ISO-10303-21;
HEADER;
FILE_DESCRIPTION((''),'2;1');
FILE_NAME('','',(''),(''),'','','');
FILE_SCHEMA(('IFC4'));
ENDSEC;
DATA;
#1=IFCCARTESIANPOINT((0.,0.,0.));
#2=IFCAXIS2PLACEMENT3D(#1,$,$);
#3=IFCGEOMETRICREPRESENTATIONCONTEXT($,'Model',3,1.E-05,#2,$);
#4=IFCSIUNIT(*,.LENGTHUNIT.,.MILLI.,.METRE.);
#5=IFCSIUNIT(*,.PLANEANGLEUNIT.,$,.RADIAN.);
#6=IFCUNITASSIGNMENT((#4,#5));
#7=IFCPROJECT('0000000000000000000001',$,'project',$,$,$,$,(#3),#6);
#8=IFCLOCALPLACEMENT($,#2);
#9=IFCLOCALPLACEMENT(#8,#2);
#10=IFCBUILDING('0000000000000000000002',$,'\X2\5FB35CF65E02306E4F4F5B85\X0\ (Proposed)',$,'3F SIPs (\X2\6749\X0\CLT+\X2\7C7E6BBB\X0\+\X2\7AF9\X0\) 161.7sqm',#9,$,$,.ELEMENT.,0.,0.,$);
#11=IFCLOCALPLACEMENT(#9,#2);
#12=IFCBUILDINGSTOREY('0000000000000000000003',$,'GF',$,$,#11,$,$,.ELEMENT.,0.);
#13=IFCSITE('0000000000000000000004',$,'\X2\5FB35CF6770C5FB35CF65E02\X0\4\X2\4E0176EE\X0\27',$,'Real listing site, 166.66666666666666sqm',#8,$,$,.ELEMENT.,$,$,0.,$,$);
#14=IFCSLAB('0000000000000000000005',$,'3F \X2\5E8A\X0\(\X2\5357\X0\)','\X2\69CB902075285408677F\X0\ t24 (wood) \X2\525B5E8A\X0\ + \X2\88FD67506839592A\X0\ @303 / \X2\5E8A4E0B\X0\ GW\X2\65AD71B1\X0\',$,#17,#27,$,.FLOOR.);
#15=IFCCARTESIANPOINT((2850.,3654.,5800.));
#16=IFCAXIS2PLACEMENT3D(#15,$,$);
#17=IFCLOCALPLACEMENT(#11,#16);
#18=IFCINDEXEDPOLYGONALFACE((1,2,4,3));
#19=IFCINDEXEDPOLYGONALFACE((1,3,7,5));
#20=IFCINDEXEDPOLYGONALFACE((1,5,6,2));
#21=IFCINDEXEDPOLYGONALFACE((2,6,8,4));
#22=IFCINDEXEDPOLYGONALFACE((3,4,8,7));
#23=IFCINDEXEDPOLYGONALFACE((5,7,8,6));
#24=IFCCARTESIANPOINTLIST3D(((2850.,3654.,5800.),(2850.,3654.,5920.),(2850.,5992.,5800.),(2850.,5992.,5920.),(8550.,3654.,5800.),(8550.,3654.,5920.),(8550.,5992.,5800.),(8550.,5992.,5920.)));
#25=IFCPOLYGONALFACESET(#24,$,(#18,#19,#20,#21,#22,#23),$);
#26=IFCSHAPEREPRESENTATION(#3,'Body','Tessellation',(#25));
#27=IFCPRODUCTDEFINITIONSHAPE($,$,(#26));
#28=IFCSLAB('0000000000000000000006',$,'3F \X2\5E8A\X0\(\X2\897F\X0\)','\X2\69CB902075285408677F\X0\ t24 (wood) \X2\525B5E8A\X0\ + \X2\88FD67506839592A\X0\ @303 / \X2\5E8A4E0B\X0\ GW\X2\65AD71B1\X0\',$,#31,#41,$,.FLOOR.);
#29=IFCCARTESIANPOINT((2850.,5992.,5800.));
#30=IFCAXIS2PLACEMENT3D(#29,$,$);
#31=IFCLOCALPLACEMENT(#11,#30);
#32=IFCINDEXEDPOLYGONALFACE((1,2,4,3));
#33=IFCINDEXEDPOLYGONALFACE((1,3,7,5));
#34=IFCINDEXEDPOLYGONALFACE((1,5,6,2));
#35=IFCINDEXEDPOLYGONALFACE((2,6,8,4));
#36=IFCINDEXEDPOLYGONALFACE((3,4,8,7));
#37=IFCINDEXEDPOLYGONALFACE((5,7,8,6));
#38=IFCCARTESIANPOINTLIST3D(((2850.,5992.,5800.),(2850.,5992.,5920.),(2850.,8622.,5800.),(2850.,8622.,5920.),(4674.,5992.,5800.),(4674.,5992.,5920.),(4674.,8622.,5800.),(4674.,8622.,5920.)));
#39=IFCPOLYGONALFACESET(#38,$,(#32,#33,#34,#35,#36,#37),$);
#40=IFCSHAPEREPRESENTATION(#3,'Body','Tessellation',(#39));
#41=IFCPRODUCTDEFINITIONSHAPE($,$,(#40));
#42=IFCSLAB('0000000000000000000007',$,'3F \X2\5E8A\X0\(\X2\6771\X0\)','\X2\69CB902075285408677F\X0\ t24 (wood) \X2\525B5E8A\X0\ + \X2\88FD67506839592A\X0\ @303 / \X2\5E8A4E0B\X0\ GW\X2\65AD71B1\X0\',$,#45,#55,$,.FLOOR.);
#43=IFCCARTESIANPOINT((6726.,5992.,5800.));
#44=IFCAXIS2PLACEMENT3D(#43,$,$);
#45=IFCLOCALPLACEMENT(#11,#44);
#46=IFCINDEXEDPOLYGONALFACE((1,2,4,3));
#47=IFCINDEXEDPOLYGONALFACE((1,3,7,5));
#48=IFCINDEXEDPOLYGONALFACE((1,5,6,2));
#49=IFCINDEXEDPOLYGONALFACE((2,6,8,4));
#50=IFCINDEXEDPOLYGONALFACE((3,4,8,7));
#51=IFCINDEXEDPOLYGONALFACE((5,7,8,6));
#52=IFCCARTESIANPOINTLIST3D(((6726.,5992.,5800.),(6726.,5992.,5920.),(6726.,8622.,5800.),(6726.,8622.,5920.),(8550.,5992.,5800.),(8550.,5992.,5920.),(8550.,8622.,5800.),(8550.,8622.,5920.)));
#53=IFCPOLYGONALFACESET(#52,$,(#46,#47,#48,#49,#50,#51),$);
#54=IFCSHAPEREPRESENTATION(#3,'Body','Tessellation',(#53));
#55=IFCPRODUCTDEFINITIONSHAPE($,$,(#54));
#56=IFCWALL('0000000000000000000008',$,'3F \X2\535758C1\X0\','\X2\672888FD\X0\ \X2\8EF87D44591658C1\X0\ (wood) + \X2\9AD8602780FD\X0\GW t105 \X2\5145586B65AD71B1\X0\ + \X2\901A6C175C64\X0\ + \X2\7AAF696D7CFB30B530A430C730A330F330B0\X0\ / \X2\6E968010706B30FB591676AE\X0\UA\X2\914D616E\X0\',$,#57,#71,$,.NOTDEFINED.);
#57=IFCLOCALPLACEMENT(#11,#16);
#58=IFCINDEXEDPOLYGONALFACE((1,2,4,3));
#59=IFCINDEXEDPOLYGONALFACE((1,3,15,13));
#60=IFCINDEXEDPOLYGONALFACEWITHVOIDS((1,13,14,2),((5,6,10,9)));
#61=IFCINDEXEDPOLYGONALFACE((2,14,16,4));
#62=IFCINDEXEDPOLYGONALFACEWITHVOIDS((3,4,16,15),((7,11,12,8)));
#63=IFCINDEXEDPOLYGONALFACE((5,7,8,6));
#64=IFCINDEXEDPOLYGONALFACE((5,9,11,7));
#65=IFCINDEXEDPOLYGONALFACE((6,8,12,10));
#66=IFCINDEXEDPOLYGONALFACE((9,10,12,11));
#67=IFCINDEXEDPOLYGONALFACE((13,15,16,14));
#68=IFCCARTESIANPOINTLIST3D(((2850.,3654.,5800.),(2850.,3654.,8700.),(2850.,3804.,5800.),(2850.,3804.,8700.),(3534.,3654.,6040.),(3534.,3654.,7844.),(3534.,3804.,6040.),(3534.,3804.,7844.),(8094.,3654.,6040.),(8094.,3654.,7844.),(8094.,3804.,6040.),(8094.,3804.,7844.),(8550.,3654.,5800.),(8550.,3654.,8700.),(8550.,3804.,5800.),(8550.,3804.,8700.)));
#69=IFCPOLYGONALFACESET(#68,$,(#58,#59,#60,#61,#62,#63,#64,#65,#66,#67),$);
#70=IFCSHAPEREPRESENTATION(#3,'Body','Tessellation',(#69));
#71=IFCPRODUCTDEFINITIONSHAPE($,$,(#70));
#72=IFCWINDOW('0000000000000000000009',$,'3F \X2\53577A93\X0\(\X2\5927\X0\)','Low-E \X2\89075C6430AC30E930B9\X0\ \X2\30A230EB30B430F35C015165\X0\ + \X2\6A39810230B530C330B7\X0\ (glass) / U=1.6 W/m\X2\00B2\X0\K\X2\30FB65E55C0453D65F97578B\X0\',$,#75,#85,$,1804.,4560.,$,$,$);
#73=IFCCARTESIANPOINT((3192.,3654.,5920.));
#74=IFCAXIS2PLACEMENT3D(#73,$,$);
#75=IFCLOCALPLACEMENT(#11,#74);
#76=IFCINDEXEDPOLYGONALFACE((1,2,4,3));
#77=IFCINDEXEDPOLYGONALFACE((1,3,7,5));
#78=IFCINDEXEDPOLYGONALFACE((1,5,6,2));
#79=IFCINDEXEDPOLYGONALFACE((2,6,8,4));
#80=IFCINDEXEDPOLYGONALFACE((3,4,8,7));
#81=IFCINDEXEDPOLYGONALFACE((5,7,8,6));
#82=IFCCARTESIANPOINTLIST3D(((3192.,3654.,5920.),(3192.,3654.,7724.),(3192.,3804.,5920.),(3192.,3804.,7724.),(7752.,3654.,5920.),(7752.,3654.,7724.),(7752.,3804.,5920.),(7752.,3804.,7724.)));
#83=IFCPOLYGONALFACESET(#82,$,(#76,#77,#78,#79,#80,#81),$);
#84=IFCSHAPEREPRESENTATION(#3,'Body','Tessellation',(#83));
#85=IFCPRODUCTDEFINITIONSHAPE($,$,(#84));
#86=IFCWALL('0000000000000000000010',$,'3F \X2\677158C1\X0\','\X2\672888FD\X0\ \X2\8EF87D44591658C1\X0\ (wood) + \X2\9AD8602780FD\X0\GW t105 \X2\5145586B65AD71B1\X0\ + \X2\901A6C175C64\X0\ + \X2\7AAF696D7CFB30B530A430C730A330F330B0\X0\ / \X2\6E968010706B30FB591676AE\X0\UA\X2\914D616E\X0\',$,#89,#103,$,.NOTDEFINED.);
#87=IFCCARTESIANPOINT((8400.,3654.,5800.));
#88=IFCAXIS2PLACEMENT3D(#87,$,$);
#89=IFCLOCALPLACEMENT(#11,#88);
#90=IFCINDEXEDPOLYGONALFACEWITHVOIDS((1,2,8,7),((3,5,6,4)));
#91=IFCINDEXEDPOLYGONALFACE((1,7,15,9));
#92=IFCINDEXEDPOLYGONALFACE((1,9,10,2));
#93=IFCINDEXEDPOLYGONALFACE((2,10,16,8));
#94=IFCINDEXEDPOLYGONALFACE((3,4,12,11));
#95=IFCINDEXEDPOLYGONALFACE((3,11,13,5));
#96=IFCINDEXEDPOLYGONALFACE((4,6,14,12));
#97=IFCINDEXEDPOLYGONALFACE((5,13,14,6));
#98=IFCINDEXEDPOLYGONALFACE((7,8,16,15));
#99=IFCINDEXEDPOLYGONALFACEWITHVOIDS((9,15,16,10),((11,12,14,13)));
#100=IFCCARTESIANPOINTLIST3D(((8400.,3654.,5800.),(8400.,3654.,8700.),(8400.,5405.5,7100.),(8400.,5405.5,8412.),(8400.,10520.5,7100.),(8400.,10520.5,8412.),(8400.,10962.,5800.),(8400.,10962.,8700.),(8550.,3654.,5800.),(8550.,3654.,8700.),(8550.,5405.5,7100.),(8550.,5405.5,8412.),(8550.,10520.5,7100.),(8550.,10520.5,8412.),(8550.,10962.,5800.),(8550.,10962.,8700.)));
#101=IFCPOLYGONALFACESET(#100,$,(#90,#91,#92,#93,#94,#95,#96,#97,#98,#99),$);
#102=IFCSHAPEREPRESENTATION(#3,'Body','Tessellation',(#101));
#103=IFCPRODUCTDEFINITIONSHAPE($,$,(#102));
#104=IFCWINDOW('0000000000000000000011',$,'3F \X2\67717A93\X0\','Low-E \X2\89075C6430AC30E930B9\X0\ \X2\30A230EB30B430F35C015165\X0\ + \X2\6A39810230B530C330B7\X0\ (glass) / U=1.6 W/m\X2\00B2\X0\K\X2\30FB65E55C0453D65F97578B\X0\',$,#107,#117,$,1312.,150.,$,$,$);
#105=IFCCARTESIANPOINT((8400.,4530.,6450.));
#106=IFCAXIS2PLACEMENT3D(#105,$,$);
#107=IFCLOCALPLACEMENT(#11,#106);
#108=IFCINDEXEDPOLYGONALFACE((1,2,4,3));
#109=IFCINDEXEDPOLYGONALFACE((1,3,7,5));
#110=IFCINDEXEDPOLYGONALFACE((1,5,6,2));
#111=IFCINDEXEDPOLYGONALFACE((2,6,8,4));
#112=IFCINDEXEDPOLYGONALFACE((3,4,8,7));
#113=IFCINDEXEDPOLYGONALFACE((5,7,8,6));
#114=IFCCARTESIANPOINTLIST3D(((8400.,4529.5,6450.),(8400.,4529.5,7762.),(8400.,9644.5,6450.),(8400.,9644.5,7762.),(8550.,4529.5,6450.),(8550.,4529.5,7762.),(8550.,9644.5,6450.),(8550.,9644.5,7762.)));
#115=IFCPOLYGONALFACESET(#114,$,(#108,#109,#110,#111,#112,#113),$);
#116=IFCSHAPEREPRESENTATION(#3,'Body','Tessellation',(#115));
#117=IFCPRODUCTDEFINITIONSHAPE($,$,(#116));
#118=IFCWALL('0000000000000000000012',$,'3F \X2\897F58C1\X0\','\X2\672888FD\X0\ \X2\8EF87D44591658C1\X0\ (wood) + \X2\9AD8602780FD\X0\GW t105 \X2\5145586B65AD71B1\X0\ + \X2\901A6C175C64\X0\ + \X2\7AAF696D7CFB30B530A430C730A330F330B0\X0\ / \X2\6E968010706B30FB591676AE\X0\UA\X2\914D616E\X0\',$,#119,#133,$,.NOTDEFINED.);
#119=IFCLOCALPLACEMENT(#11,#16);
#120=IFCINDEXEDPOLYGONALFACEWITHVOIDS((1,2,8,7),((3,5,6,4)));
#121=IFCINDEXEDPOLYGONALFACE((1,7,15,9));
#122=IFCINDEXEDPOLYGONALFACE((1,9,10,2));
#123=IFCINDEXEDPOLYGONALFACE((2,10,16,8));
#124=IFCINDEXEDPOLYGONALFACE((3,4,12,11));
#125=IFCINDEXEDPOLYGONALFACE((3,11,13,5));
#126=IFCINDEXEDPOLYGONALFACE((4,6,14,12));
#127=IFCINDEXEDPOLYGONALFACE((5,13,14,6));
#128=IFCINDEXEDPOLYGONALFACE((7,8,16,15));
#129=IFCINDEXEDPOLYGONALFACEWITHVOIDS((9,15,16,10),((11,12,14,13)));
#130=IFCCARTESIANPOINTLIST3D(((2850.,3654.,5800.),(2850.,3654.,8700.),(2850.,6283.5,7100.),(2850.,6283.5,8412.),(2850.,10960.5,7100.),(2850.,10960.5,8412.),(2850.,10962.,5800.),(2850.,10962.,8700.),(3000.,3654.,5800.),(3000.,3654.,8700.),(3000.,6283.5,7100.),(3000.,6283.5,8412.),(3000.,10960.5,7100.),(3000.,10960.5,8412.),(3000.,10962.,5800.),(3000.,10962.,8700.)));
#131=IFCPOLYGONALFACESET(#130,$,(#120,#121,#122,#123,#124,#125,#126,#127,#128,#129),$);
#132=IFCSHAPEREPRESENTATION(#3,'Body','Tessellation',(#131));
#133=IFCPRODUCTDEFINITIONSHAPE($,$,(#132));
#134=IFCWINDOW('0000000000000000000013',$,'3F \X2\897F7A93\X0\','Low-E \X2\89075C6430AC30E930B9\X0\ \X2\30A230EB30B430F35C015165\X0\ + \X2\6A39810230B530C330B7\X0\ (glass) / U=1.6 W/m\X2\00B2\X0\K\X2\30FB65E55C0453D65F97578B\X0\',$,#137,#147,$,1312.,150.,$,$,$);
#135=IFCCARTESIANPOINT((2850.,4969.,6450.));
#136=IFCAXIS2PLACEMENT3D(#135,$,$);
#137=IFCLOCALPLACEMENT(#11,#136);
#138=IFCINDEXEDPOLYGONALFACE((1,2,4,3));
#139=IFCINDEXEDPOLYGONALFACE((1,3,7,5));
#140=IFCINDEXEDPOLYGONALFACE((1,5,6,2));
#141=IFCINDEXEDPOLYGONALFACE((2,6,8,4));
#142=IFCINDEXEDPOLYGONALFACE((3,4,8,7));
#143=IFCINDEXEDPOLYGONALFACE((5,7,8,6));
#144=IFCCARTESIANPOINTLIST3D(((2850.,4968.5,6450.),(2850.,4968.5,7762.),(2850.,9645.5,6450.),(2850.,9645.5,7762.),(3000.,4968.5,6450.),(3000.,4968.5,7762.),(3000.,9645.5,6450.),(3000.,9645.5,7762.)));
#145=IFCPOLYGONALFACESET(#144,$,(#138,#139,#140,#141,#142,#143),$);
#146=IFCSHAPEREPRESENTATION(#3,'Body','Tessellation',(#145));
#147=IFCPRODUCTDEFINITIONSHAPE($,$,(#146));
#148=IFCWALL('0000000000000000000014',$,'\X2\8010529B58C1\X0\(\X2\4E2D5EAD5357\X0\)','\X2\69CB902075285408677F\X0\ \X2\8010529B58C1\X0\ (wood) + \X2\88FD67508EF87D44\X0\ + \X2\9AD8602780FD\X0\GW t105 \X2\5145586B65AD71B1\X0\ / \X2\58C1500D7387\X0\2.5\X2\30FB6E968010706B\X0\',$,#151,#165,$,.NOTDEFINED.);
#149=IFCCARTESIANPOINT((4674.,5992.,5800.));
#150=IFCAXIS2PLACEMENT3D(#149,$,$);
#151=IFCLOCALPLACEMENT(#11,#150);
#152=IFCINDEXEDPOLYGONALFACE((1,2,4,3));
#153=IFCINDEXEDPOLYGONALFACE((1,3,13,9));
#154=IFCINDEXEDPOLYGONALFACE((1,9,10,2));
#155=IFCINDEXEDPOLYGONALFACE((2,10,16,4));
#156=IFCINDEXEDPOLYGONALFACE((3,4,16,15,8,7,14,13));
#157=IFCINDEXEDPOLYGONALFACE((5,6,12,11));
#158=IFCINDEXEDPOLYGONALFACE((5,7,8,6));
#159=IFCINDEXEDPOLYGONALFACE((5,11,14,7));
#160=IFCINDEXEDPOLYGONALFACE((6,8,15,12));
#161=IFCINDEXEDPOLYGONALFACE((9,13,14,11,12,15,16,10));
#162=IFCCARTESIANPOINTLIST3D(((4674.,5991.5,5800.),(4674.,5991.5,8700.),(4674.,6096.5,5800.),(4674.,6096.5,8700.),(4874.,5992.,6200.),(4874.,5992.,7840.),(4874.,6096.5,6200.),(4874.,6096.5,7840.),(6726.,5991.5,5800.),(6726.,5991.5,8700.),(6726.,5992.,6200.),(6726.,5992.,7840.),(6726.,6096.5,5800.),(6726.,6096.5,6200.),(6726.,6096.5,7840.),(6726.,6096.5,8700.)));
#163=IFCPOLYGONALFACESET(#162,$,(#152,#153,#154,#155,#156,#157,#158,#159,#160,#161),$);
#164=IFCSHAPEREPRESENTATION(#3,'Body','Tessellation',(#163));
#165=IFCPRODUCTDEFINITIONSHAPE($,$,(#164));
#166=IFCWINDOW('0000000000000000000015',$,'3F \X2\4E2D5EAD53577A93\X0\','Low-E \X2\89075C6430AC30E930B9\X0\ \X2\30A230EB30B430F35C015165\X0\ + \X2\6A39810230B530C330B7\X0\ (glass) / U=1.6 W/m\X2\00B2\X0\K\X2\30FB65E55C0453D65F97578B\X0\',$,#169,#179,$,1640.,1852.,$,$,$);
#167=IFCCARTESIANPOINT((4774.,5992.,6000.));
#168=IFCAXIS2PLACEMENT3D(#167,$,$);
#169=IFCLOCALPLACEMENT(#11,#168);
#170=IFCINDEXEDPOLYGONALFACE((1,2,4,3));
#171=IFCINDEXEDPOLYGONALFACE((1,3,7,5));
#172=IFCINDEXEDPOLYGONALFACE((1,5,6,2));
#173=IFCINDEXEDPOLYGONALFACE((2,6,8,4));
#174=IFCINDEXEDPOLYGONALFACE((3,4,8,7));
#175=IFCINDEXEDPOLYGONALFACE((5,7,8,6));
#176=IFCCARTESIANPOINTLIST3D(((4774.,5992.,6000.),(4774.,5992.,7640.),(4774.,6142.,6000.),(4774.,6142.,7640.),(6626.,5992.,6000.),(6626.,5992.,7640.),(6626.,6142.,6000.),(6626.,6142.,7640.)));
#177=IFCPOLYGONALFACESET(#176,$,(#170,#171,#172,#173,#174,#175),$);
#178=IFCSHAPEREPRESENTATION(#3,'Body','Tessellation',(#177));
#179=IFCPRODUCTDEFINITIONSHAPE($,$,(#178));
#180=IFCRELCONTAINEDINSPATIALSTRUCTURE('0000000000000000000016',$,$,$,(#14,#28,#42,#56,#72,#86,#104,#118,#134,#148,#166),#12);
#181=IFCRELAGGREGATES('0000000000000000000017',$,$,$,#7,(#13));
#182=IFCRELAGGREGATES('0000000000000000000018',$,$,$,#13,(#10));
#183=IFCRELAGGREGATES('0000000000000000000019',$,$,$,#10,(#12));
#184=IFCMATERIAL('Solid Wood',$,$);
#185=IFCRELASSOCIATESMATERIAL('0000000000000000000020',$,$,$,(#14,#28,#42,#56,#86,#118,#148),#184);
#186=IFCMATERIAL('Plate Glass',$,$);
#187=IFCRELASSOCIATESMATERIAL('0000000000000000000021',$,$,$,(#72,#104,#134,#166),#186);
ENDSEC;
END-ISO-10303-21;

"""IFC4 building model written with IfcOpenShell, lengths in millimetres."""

from ifc_helpers import new_model, si_unit, frame, frame_2d, origin, place, context, project, spatial, rectangle, extrude, material, element, fill, save


model = new_model("IFC4")

# Units and contexts
model_context = context("Model", 3, precision=1e-05, world=origin())
ifc_project = project(units=[si_unit("LENGTHUNIT", "METRE", prefix="MILLI"), si_unit("PLANEANGLEUNIT", "RADIAN")], contexts=[model_context])

# Site, building, storey
site_placement = place(None, origin())
site = spatial("IfcSite", under=ifc_project, at=site_placement, Name="徳島県徳島市4丁目27", ObjectType="Real listing site, 166.66666666666666sqm", CompositionType="ELEMENT", RefElevation=0.0)
building_placement = place(site_placement, origin())
building = spatial("IfcBuilding", under=site, at=building_placement, Name="徳島市の住宅 (Proposed)", ObjectType="3F SIPs (杉CLT+籾殻+竹) 161.7sqm", CompositionType="ELEMENT", ElevationOfRefHeight=0.0, ElevationOfTerrain=0.0)
storey_placement = place(building_placement, origin())
storey = spatial("IfcBuildingStorey", under=building, at=storey_placement, Name="GF", CompositionType="ELEMENT", Elevation=0.0)

# Slabs
ifc_material_1 = material(Name="Solid Wood")
slab_1_placement = place(storey_placement, frame((2850.0, 3654.0, 5800.0)))
element("IfcSlab", 1, at=slab_1_placement, inside=storey, material=ifc_material_1, Name="3F 床(南)", Description="構造用合板 t24 (wood) 剛床 + 製材根太 @303 / 床下 GW断熱", PredefinedType="FLOOR", context=model_context, shape_type="SweptSolid", body=[
    extrude(rectangle(XDim=5700.0, YDim=2338.0, at=frame_2d((2850.0, 1169.0))), frame((2850.0, 3654.0, 5800.0)), (0.0, 0.0, 1.0), 120.0),
])
slab_2_placement = place(storey_placement, frame((2850.0, 5992.0, 5800.0)))
element("IfcSlab", 2, at=slab_2_placement, inside=storey, material=ifc_material_1, Name="3F 床(西)", Description="構造用合板 t24 (wood) 剛床 + 製材根太 @303 / 床下 GW断熱", PredefinedType="FLOOR", context=model_context, shape_type="SweptSolid", body=[
    extrude(rectangle(XDim=1824.0, YDim=2630.0, at=frame_2d((912.0, 1315.0))), frame((2850.0, 5992.0, 5800.0)), (0.0, 0.0, 1.0), 120.0),
])
slab_3_placement = place(storey_placement, frame((6726.0, 5992.0, 5800.0)))
element("IfcSlab", 3, at=slab_3_placement, inside=storey, material=ifc_material_1, Name="3F 床(東)", Description="構造用合板 t24 (wood) 剛床 + 製材根太 @303 / 床下 GW断熱", PredefinedType="FLOOR", context=model_context, shape_type="SweptSolid", body=[
    extrude(rectangle(XDim=1824.0, YDim=2630.0, at=frame_2d((912.0, 1315.0))), frame((6726.0, 5992.0, 5800.0)), (0.0, 0.0, 1.0), 120.0),
])

# Walls, openings, windows
wall_1_placement = place(storey_placement, frame((2850.0, 3654.0, 5800.0)))
wall_1 = element("IfcWall", 4, at=wall_1_placement, inside=storey, material=ifc_material_1, Name="3F 南壁", Description="木製 軸組外壁 (wood) + 高性能GW t105 充填断熱 + 通気層 + 窯業系サイディング / 準耐火・外皮UA配慮", PredefinedType="NOTDEFINED", context=model_context, shape_type="SweptSolid", body=[
    extrude(rectangle(XDim=5700.0, YDim=150.0, at=frame_2d((2850.0, 75.0))), frame((2850.0, 3654.0, 5800.0)), (0.0, 0.0, 1.0), 2900.0),
])
opening_1_placement = place(storey_placement, frame((3192.0, 3654.0, 5920.0)))
opening_1 = element("IfcOpeningElement", 5, at=opening_1_placement, cuts=wall_1, PredefinedType="NOTDEFINED", context=model_context, shape_type="SweptSolid", body=[
    extrude(rectangle(XDim=4560.0, YDim=150.0, at=frame_2d((2280.0, 75.0))), frame((3192.0, 3654.0, 5920.0)), (0.0, 0.0, 1.0), 1804.0),
])
ifc_material_2 = material(Name="Plate Glass")
window_1_placement = place(storey_placement, frame((3192.0, 3654.0, 5920.0)))
window_1 = element("IfcWindow", 6, at=window_1_placement, inside=storey, material=ifc_material_2, Name="3F 南窓(大)", Description="Low-E 複層ガラス アルゴン封入 + 樹脂サッシ (glass) / U=1.6 W/m²K・日射取得型", OverallHeight=1804.0, OverallWidth=4560.0, context=model_context, shape_type="SweptSolid", body=[
    extrude(rectangle(XDim=4560.0, YDim=150.0, at=frame_2d((2280.0, 75.0))), frame((3192.0, 3654.0, 5920.0)), (0.0, 0.0, 1.0), 1804.0),
])
fill(opening_1, window_1)
wall_2_placement = place(storey_placement, frame((8400.0, 3654.0, 5800.0)))
wall_2 = element("IfcWall", 7, at=wall_2_placement, inside=storey, material=ifc_material_1, Name="3F 東壁", Description="木製 軸組外壁 (wood) + 高性能GW t105 充填断熱 + 通気層 + 窯業系サイディング / 準耐火・外皮UA配慮", PredefinedType="NOTDEFINED", context=model_context, shape_type="SweptSolid", body=[
    extrude(rectangle(XDim=150.0, YDim=7308.0, at=frame_2d((75.0, 3654.0))), frame((8400.0, 3654.0, 5800.0)), (0.0, 0.0, 1.0), 2900.0),
])
opening_2_placement = place(storey_placement, frame((8400.0, 4530.0, 6450.0)))
opening_2 = element("IfcOpeningElement", 8, at=opening_2_placement, cuts=wall_2, PredefinedType="NOTDEFINED", context=model_context, shape_type="SweptSolid", body=[
    extrude(rectangle(XDim=150.0, YDim=5115.0, at=frame_2d((75.0, 2557.0))), frame((8400.0, 4530.0, 6450.0)), (0.0, 0.0, 1.0), 1312.0),
])
window_2_placement = place(storey_placement, frame((8400.0, 4530.0, 6450.0)))
window_2 = element("IfcWindow", 9, at=window_2_placement, inside=storey, material=ifc_material_2, Name="3F 東窓", Description="Low-E 複層ガラス アルゴン封入 + 樹脂サッシ (glass) / U=1.6 W/m²K・日射取得型", OverallHeight=1312.0, OverallWidth=150.0, context=model_context, shape_type="SweptSolid", body=[
    extrude(rectangle(XDim=150.0, YDim=5115.0, at=frame_2d((75.0, 2557.0))), frame((8400.0, 4530.0, 6450.0)), (0.0, 0.0, 1.0), 1312.0),
])
fill(opening_2, window_2)
wall_3_placement = place(storey_placement, frame((2850.0, 3654.0, 5800.0)))
wall_3 = element("IfcWall", 10, at=wall_3_placement, inside=storey, material=ifc_material_1, Name="3F 西壁", Description="木製 軸組外壁 (wood) + 高性能GW t105 充填断熱 + 通気層 + 窯業系サイディング / 準耐火・外皮UA配慮", PredefinedType="NOTDEFINED", context=model_context, shape_type="SweptSolid", body=[
    extrude(rectangle(XDim=150.0, YDim=7308.0, at=frame_2d((75.0, 3654.0))), frame((2850.0, 3654.0, 5800.0)), (0.0, 0.0, 1.0), 2900.0),
])
opening_3_placement = place(storey_placement, frame((2850.0, 4969.0, 6450.0)))
opening_3 = element("IfcOpeningElement", 11, at=opening_3_placement, cuts=wall_3, PredefinedType="NOTDEFINED", context=model_context, shape_type="SweptSolid", body=[
    extrude(rectangle(XDim=150.0, YDim=4677.0, at=frame_2d((75.0, 2338.0))), frame((2850.0, 4969.0, 6450.0)), (0.0, 0.0, 1.0), 1312.0),
])
window_3_placement = place(storey_placement, frame((2850.0, 4969.0, 6450.0)))
window_3 = element("IfcWindow", 12, at=window_3_placement, inside=storey, material=ifc_material_2, Name="3F 西窓", Description="Low-E 複層ガラス アルゴン封入 + 樹脂サッシ (glass) / U=1.6 W/m²K・日射取得型", OverallHeight=1312.0, OverallWidth=150.0, context=model_context, shape_type="SweptSolid", body=[
    extrude(rectangle(XDim=150.0, YDim=4677.0, at=frame_2d((75.0, 2338.0))), frame((2850.0, 4969.0, 6450.0)), (0.0, 0.0, 1.0), 1312.0),
])
fill(opening_3, window_3)
wall_4_placement = place(storey_placement, frame((4674.0, 5992.0, 5800.0)))
wall_4 = element("IfcWall", 13, at=wall_4_placement, inside=storey, material=ifc_material_1, Name="耐力壁(中庭南)", Description="構造用合板 耐力壁 (wood) + 製材軸組 + 高性能GW t105 充填断熱 / 壁倍率2.5・準耐火", PredefinedType="NOTDEFINED", context=model_context, shape_type="SweptSolid", body=[
    extrude(rectangle(XDim=2052.0, YDim=105.0, at=frame_2d((1026.0, 52.0))), frame((4674.0, 5992.0, 5800.0)), (0.0, 0.0, 1.0), 2900.0),
])
opening_4_placement = place(storey_placement, frame((4774.0, 5992.0, 6000.0)))
opening_4 = element("IfcOpeningElement", 14, at=opening_4_placement, cuts=wall_4, PredefinedType="NOTDEFINED", context=model_context, shape_type="SweptSolid", body=[
    extrude(rectangle(XDim=1852.0, YDim=150.0, at=frame_2d((926.0, 75.0))), frame((4774.0, 5992.0, 6000.0)), (0.0, 0.0, 1.0), 1640.0),
])
window_4_placement = place(storey_placement, frame((4774.0, 5992.0, 6000.0)))
window_4 = element("IfcWindow", 15, at=window_4_placement, inside=storey, material=ifc_material_2, Name="3F 中庭南窓", Description="Low-E 複層ガラス アルゴン封入 + 樹脂サッシ (glass) / U=1.6 W/m²K・日射取得型", OverallHeight=1640.0, OverallWidth=1852.0, context=model_context, shape_type="SweptSolid", body=[
    extrude(rectangle(XDim=1852.0, YDim=150.0, at=frame_2d((926.0, 75.0))), frame((4774.0, 5992.0, 6000.0)), (0.0, 0.0, 1.0), 1640.0),
])
fill(opening_4, window_4)

save(model, "model.ifc")
